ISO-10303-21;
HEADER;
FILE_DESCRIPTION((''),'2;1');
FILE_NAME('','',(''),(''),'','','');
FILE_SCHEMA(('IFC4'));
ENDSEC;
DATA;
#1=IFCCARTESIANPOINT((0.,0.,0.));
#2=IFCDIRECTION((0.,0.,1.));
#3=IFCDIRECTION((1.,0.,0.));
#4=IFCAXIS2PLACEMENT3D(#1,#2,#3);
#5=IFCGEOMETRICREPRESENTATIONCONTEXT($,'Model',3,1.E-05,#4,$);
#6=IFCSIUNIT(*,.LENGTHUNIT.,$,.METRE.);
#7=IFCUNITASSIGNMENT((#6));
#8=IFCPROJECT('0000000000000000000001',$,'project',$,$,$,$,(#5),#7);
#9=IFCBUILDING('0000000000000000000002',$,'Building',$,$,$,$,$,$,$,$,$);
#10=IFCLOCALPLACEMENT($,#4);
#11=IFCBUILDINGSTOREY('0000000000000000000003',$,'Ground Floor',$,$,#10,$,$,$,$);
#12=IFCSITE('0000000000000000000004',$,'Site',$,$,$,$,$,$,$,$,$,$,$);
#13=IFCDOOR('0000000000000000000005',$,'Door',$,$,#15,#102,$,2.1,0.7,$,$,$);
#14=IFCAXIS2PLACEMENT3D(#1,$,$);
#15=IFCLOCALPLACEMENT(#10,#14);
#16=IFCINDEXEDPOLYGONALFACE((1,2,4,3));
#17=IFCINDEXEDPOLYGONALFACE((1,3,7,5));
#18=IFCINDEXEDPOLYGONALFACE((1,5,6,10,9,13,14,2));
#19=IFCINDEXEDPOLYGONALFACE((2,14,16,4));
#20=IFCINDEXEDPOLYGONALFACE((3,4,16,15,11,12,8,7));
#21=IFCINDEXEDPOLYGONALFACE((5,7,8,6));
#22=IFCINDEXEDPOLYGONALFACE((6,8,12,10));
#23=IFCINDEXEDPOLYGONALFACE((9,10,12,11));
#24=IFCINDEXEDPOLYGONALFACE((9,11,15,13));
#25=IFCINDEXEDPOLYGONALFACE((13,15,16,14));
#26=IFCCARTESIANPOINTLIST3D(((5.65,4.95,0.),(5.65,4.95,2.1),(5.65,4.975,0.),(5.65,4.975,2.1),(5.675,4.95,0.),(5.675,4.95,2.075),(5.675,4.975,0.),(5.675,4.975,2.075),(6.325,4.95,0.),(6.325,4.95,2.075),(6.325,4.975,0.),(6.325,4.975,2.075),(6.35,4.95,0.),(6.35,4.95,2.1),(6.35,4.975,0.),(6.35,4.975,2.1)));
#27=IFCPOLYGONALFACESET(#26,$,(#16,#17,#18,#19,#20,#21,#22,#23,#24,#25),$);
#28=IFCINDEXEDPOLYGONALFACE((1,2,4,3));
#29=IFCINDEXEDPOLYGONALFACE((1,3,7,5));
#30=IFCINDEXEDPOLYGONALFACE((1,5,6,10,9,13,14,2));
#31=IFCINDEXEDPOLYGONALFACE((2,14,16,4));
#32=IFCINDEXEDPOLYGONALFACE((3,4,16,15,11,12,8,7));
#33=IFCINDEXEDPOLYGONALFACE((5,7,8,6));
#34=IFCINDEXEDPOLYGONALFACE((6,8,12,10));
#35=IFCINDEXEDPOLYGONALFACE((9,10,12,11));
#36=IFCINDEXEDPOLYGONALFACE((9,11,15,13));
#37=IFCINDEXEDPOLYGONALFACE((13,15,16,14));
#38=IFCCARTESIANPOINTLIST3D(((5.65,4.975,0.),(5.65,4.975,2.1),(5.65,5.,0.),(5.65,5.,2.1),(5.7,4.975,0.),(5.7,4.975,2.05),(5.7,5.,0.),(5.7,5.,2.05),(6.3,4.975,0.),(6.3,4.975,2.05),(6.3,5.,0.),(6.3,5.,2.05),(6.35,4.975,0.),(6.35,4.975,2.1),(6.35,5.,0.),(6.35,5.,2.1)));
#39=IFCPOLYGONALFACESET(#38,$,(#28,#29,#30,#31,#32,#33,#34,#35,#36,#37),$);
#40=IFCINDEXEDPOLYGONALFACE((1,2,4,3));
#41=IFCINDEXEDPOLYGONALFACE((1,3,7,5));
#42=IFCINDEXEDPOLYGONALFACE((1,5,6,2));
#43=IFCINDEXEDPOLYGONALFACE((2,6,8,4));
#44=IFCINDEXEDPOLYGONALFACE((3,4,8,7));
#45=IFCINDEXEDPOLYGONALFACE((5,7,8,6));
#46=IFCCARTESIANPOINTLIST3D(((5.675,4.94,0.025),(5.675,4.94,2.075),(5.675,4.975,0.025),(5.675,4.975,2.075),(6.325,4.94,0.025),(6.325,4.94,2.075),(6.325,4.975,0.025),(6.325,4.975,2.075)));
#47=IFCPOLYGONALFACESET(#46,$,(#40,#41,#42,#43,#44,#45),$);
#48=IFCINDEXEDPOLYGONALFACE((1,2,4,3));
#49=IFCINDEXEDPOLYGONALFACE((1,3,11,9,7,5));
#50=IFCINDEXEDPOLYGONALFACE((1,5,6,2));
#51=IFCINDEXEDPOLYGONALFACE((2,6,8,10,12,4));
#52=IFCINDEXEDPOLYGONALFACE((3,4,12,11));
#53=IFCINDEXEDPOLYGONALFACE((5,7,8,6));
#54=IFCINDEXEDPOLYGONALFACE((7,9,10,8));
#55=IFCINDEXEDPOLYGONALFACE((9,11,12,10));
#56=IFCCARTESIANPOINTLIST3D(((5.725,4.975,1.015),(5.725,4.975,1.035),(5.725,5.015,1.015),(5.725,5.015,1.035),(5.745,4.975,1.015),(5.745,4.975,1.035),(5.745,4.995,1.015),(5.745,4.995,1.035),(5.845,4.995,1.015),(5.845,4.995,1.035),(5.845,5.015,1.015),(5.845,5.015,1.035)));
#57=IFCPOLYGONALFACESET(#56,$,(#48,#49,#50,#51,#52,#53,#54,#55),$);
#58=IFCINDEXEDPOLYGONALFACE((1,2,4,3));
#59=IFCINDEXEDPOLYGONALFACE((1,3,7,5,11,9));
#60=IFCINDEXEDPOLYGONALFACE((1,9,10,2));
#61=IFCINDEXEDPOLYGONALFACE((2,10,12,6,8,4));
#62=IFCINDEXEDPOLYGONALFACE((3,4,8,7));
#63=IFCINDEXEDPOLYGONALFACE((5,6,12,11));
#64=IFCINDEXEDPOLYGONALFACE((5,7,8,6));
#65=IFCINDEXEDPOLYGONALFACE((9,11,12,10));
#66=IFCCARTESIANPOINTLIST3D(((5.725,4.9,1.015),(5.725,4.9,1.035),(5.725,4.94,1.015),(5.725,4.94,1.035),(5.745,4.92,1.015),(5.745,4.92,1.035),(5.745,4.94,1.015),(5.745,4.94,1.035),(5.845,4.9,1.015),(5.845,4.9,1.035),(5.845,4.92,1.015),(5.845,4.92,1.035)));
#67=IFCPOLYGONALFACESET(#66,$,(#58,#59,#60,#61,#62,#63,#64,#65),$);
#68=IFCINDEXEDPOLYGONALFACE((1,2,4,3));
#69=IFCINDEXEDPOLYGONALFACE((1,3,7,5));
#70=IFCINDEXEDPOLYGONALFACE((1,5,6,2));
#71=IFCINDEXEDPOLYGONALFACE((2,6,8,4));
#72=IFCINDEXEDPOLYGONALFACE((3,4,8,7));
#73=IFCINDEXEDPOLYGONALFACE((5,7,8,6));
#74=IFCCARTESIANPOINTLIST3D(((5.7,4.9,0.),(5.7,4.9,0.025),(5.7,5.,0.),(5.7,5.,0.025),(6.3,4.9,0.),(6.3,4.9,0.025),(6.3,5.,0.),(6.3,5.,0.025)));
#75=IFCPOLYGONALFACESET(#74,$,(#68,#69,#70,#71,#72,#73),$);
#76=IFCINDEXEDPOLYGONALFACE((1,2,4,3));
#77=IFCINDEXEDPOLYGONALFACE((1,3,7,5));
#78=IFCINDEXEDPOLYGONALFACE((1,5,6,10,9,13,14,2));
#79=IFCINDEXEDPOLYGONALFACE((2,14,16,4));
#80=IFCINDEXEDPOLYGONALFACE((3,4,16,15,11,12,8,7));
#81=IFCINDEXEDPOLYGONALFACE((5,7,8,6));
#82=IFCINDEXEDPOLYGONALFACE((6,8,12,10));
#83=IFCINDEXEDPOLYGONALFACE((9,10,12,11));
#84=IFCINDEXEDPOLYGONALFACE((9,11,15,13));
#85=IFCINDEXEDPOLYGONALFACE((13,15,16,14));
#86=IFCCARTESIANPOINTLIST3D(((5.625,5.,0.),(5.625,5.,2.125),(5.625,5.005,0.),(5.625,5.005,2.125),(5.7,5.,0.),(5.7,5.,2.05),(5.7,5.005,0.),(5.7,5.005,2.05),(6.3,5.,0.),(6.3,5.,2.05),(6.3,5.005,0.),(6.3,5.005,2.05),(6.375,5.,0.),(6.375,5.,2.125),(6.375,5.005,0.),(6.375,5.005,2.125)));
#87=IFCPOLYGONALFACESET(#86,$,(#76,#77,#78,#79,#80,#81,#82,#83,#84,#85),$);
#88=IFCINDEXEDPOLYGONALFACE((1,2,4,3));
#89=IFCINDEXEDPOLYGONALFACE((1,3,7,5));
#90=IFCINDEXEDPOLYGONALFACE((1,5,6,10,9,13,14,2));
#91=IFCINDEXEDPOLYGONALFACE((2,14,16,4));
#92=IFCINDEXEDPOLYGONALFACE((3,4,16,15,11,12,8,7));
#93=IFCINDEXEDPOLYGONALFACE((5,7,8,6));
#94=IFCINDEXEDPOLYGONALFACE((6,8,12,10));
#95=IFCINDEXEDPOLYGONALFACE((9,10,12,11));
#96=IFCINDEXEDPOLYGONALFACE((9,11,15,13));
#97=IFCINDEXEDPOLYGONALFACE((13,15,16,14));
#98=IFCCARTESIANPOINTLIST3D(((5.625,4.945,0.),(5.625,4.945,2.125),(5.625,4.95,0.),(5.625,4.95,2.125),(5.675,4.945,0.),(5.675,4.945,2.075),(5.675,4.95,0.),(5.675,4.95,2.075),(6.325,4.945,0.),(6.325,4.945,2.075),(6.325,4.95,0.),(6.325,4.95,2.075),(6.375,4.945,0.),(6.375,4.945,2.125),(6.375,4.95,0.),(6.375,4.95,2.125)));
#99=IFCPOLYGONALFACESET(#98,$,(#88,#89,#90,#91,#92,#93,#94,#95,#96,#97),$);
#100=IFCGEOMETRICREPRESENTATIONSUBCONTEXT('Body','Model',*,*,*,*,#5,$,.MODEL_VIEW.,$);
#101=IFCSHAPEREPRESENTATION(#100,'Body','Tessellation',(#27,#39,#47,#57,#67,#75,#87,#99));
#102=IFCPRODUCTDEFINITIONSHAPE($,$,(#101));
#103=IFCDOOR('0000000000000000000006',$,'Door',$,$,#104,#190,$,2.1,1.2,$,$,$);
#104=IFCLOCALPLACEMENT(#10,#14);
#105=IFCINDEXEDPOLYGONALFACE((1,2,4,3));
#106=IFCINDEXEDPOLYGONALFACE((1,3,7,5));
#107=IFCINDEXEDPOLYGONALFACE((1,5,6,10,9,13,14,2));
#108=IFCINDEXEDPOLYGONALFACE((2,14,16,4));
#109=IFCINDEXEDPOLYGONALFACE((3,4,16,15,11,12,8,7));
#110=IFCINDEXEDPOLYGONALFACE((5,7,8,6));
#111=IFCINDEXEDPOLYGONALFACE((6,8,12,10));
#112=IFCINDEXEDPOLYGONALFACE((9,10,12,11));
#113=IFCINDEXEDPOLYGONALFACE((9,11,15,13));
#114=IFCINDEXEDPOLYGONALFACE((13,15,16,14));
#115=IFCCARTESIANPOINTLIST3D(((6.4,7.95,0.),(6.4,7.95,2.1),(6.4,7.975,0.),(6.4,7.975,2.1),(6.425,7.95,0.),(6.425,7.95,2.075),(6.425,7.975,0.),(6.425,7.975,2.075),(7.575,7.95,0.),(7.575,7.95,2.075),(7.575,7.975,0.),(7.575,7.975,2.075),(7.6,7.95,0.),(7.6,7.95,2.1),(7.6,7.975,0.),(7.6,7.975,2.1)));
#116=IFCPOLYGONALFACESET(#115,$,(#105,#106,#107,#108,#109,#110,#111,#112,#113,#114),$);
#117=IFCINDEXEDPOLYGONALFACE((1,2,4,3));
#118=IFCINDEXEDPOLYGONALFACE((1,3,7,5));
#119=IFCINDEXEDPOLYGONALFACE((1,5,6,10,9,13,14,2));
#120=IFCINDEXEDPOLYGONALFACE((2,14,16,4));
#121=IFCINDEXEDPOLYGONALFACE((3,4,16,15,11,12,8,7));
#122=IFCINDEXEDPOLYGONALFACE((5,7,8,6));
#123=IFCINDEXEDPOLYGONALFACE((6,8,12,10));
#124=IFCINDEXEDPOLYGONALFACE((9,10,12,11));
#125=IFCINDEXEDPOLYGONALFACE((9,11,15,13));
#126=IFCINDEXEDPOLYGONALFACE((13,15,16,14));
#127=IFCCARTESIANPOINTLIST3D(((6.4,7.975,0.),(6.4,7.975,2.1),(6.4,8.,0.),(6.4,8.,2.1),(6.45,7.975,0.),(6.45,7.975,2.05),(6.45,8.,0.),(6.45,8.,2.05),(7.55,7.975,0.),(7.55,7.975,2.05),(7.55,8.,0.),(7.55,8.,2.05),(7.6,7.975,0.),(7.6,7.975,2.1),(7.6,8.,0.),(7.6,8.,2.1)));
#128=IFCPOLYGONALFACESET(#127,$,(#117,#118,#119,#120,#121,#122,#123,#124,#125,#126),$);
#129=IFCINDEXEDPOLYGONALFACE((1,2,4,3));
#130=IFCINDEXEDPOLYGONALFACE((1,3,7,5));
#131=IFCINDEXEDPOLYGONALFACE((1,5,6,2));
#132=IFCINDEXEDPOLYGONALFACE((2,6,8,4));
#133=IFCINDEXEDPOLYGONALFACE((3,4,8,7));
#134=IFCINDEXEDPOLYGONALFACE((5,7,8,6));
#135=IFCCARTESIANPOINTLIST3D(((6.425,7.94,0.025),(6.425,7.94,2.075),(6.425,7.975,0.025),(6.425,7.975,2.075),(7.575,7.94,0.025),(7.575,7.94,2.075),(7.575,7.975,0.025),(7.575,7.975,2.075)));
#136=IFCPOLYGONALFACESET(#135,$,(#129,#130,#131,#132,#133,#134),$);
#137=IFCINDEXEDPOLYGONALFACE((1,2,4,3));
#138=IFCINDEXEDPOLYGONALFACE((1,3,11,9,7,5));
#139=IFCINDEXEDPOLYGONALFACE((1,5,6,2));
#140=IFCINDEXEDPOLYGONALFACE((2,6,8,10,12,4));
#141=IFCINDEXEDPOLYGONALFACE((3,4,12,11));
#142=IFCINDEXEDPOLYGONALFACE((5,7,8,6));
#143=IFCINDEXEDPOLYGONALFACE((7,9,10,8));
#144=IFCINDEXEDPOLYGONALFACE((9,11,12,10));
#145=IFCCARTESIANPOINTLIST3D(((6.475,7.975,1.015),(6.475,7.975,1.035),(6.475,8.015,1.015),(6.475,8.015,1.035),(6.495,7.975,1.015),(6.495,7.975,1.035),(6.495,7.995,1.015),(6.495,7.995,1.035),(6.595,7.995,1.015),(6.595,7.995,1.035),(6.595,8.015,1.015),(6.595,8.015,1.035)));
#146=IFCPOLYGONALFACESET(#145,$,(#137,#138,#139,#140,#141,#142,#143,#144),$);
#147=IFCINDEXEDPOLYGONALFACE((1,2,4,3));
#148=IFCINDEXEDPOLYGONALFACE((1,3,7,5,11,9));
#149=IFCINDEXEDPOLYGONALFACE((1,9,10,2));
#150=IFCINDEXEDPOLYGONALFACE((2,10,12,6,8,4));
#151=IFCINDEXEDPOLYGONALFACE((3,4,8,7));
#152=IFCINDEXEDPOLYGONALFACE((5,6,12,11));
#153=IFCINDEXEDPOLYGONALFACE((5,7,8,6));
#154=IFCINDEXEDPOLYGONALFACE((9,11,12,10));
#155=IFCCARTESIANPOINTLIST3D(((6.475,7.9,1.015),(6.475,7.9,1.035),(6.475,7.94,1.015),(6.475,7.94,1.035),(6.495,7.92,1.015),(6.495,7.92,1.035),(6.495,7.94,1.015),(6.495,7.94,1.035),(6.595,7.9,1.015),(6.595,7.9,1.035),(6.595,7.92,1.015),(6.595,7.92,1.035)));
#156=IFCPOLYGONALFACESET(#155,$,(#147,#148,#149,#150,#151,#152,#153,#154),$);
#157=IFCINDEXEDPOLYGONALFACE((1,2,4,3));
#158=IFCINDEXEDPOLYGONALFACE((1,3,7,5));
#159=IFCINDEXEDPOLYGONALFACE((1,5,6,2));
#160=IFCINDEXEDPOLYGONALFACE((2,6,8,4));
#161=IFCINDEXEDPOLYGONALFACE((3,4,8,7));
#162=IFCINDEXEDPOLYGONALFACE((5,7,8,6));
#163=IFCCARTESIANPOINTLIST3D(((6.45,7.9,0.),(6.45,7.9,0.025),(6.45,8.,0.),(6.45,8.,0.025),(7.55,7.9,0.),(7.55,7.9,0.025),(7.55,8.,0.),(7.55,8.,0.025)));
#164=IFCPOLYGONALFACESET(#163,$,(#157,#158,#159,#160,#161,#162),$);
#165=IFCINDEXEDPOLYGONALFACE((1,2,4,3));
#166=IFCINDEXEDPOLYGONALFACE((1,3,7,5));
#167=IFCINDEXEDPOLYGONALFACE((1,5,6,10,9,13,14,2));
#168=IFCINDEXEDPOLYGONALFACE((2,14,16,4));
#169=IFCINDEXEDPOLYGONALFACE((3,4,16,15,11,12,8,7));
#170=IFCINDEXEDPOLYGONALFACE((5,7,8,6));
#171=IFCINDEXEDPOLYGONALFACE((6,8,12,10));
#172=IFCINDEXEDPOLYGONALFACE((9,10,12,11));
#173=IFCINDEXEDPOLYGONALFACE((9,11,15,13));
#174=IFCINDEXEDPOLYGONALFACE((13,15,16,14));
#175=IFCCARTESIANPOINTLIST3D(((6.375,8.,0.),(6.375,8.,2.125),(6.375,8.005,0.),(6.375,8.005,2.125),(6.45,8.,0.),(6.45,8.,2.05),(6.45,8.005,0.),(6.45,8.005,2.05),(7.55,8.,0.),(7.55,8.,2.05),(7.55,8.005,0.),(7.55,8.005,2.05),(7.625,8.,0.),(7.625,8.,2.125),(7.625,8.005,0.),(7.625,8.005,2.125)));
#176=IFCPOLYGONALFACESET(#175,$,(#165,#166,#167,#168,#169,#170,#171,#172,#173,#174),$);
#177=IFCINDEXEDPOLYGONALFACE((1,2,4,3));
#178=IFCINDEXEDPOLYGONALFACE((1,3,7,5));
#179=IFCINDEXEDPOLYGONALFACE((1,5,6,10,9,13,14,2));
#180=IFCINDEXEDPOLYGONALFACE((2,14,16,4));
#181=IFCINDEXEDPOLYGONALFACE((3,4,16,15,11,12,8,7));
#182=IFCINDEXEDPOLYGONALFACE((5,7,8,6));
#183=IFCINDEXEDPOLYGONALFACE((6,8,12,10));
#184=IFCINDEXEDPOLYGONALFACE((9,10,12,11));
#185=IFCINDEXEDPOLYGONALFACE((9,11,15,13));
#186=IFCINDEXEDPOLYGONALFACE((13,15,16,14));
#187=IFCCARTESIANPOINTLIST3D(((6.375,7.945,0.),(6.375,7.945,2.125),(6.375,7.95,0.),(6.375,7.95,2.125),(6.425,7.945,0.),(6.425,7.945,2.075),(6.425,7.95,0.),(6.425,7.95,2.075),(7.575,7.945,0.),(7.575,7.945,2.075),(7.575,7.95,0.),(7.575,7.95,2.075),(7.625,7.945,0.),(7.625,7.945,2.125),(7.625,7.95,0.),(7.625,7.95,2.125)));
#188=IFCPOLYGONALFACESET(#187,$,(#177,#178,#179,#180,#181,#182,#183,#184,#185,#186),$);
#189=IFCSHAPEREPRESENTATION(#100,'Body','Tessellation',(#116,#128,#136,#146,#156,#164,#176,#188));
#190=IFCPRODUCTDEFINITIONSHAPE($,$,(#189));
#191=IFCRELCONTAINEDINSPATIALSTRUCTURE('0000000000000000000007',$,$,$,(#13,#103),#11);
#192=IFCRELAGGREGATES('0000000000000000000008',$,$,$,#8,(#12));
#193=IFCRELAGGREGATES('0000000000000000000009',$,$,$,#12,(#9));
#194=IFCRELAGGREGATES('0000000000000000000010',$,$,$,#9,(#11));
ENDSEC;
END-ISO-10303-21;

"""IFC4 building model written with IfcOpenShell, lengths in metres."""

from ifc_helpers import new_model, si_unit, frame, origin_with_axes, place, context, subcontext, project, spatial, line, indexed_curve, outline, extrude, element, save


model = new_model("IFC4")

# Units and contexts
model_context = context("Model", 3, precision=1e-05, world=origin_with_axes())
body_context = subcontext(model_context, "Body", "Model", "MODEL_VIEW")
ifc_project = project(units=[si_unit("LENGTHUNIT", "METRE")], contexts=[model_context])

# Site, building, storey
site = spatial("IfcSite", under=ifc_project, Name="Site")
building = spatial("IfcBuilding", under=site, Name="Building")
storey_placement = place(None, origin_with_axes())
storey = spatial("IfcBuildingStorey", under=building, at=storey_placement, Name="Ground Floor")

# Doors
door_1_placement = place(storey_placement, frame((6.35, 5.0, 0.0), z_axis=(0.0, 0.0, 1.0), x_axis=(-1.0, 0.0, 0.0)))
element("IfcDoor", 1, at=door_1_placement, inside=storey, Name="Door", OverallHeight=2.1, OverallWidth=0.7, context=body_context, shape_type="SweptSolid", body=[
    extrude(outline(indexed_curve([(0.0, 0.0), (0.0, 2.1), (0.7, 2.1), (0.7, 0.0), (0.675, 0.0), (0.675, 2.075), (0.025, 2.075), (0.025, 0.0)], segments=[line(1, 2, 3, 4, 5, 6, 7, 8, 1)])), frame((0.0, 0.025, 0.0), z_axis=(0.0, -1.0, 0.0), x_axis=(1.0, 0.0, 0.0)), (0.0, 0.0, -1.0), 0.025),
    extrude(outline(indexed_curve([(0.0, 0.0), (0.0, 2.1), (0.7, 2.1), (0.7, 0.0), (0.65, 0.0), (0.65, 2.05), (0.05, 2.05), (0.05, 0.0)], segments=[line(1, 2, 3, 4, 5, 6, 7, 8, 1)])), frame((0.0, 0.0, 0.0), z_axis=(0.0, -1.0, 0.0), x_axis=(1.0, 0.0, 0.0)), (0.0, 0.0, -1.0), 0.025),
    extrude(outline(indexed_curve([(0.0, 0.0), (0.65, 0.0), (0.65, 0.035), (0.0, 0.035)], segments=[line(1, 2, 3, 4, 1)])), frame((0.025, 0.025, 0.025), z_axis=(0.0, 0.0, 1.0), x_axis=(1.0, 0.0, 0.0)), (0.0, 0.0, 1.0), 2.05),
    extrude(outline(indexed_curve([(0.0, 0.0), (0.0, -0.04), (-0.12, -0.04), (-0.12, -0.02), (-0.02, -0.02), (-0.02, 0.0)], segments=[line(1, 2, 3, 4, 5, 6, 1)])), frame((0.625, 0.025, 1.015), z_axis=(0.0, 0.0, 1.0), x_axis=(1.0, 0.0, 0.0)), (0.0, 0.0, 1.0), 0.02),
    extrude(outline(indexed_curve([(0.0, 0.0), (0.0, 0.04), (-0.12, 0.04), (-0.12, 0.02), (-0.02, 0.02), (-0.02, 0.0)], segments=[line(1, 2, 3, 4, 5, 6, 1)])), frame((0.625, 0.06, 1.015), z_axis=(0.0, 0.0, 1.0), x_axis=(1.0, 0.0, 0.0)), (0.0, 0.0, 1.0), 0.02),
    extrude(outline(indexed_curve([(0.0, 0.0), (0.6, 0.0), (0.6, 0.1), (0.0, 0.1)], segments=[line(1, 2, 3, 4, 1)])), frame((0.05, 0.0, 0.0), z_axis=(0.0, 0.0, 1.0), x_axis=(1.0, 0.0, 0.0)), (0.0, 0.0, 1.0), 0.025),
    extrude(outline(indexed_curve([(0.0, 0.0), (0.0, 2.125), (0.75, 2.125), (0.75, 0.0), (0.675, 0.0), (0.675, 2.05), (0.075, 2.05), (0.075, 0.0)], segments=[line(1, 2, 3, 4, 5, 6, 7, 8, 1)])), frame((-0.025, -0.005, 0.0), z_axis=(0.0, -1.0, 0.0), x_axis=(1.0, 0.0, 0.0)), (0.0, 0.0, -1.0), 0.005),
    extrude(outline(indexed_curve([(0.0, 0.0), (0.0, 2.125), (0.75, 2.125), (0.75, 0.0), (0.7, 0.0), (0.7, 2.075), (0.05, 2.075), (0.05, 0.0)], segments=[line(1, 2, 3, 4, 5, 6, 7, 8, 1)])), frame((-0.025, 0.05, 0.0), z_axis=(0.0, -1.0, 0.0), x_axis=(1.0, 0.0, 0.0)), (0.0, 0.0, -1.0), 0.005),
])
door_2_placement = place(storey_placement, frame((7.6, 8.0, 0.0), z_axis=(0.0, 0.0, 1.0), x_axis=(-1.0, 0.0, 0.0)))
element("IfcDoor", 2, at=door_2_placement, inside=storey, Name="Door", OverallHeight=2.1, OverallWidth=1.2, context=body_context, shape_type="SweptSolid", body=[
    extrude(outline(indexed_curve([(0.0, 0.0), (0.0, 2.1), (1.2, 2.1), (1.2, 0.0), (1.175, 0.0), (1.175, 2.075), (0.025, 2.075), (0.025, 0.0)], segments=[line(1, 2, 3, 4, 5, 6, 7, 8, 1)])), frame((0.0, 0.025, 0.0), z_axis=(0.0, -1.0, 0.0), x_axis=(1.0, 0.0, 0.0)), (0.0, 0.0, -1.0), 0.025),
    extrude(outline(indexed_curve([(0.0, 0.0), (0.0, 2.1), (1.2, 2.1), (1.2, 0.0), (1.15, 0.0), (1.15, 2.05), (0.05, 2.05), (0.05, 0.0)], segments=[line(1, 2, 3, 4, 5, 6, 7, 8, 1)])), frame((0.0, 0.0, 0.0), z_axis=(0.0, -1.0, 0.0), x_axis=(1.0, 0.0, 0.0)), (0.0, 0.0, -1.0), 0.025),
    extrude(outline(indexed_curve([(0.0, 0.0), (1.15, 0.0), (1.15, 0.035), (0.0, 0.035)], segments=[line(1, 2, 3, 4, 1)])), frame((0.025, 0.025, 0.025), z_axis=(0.0, 0.0, 1.0), x_axis=(1.0, 0.0, 0.0)), (0.0, 0.0, 1.0), 2.05),
    extrude(outline(indexed_curve([(0.0, 0.0), (0.0, -0.04), (-0.12, -0.04), (-0.12, -0.02), (-0.02, -0.02), (-0.02, 0.0)], segments=[line(1, 2, 3, 4, 5, 6, 1)])), frame((1.125, 0.025, 1.015), z_axis=(0.0, 0.0, 1.0), x_axis=(1.0, 0.0, 0.0)), (0.0, 0.0, 1.0), 0.02),
    extrude(outline(indexed_curve([(0.0, 0.0), (0.0, 0.04), (-0.12, 0.04), (-0.12, 0.02), (-0.02, 0.02), (-0.02, 0.0)], segments=[line(1, 2, 3, 4, 5, 6, 1)])), frame((1.125, 0.06, 1.015), z_axis=(0.0, 0.0, 1.0), x_axis=(1.0, 0.0, 0.0)), (0.0, 0.0, 1.0), 0.02),
    extrude(outline(indexed_curve([(0.0, 0.0), (1.1, 0.0), (1.1, 0.1), (0.0, 0.1)], segments=[line(1, 2, 3, 4, 1)])), frame((0.05, 0.0, 0.0), z_axis=(0.0, 0.0, 1.0), x_axis=(1.0, 0.0, 0.0)), (0.0, 0.0, 1.0), 0.025),
    extrude(outline(indexed_curve([(0.0, 0.0), (0.0, 2.125), (1.25, 2.125), (1.25, 0.0), (1.175, 0.0), (1.175, 2.05), (0.075, 2.05), (0.075, 0.0)], segments=[line(1, 2, 3, 4, 5, 6, 7, 8, 1)])), frame((-0.025, -0.005, 0.0), z_axis=(0.0, -1.0, 0.0), x_axis=(1.0, 0.0, 0.0)), (0.0, 0.0, -1.0), 0.005),
    extrude(outline(indexed_curve([(0.0, 0.0), (0.0, 2.125), (1.25, 2.125), (1.25, 0.0), (1.2, 0.0), (1.2, 2.075), (0.05, 2.075), (0.05, 0.0)], segments=[line(1, 2, 3, 4, 5, 6, 7, 8, 1)])), frame((-0.025, 0.05, 0.0), z_axis=(0.0, -1.0, 0.0), x_axis=(1.0, 0.0, 0.0)), (0.0, 0.0, -1.0), 0.005),
])

save(model, "model.ifc")
